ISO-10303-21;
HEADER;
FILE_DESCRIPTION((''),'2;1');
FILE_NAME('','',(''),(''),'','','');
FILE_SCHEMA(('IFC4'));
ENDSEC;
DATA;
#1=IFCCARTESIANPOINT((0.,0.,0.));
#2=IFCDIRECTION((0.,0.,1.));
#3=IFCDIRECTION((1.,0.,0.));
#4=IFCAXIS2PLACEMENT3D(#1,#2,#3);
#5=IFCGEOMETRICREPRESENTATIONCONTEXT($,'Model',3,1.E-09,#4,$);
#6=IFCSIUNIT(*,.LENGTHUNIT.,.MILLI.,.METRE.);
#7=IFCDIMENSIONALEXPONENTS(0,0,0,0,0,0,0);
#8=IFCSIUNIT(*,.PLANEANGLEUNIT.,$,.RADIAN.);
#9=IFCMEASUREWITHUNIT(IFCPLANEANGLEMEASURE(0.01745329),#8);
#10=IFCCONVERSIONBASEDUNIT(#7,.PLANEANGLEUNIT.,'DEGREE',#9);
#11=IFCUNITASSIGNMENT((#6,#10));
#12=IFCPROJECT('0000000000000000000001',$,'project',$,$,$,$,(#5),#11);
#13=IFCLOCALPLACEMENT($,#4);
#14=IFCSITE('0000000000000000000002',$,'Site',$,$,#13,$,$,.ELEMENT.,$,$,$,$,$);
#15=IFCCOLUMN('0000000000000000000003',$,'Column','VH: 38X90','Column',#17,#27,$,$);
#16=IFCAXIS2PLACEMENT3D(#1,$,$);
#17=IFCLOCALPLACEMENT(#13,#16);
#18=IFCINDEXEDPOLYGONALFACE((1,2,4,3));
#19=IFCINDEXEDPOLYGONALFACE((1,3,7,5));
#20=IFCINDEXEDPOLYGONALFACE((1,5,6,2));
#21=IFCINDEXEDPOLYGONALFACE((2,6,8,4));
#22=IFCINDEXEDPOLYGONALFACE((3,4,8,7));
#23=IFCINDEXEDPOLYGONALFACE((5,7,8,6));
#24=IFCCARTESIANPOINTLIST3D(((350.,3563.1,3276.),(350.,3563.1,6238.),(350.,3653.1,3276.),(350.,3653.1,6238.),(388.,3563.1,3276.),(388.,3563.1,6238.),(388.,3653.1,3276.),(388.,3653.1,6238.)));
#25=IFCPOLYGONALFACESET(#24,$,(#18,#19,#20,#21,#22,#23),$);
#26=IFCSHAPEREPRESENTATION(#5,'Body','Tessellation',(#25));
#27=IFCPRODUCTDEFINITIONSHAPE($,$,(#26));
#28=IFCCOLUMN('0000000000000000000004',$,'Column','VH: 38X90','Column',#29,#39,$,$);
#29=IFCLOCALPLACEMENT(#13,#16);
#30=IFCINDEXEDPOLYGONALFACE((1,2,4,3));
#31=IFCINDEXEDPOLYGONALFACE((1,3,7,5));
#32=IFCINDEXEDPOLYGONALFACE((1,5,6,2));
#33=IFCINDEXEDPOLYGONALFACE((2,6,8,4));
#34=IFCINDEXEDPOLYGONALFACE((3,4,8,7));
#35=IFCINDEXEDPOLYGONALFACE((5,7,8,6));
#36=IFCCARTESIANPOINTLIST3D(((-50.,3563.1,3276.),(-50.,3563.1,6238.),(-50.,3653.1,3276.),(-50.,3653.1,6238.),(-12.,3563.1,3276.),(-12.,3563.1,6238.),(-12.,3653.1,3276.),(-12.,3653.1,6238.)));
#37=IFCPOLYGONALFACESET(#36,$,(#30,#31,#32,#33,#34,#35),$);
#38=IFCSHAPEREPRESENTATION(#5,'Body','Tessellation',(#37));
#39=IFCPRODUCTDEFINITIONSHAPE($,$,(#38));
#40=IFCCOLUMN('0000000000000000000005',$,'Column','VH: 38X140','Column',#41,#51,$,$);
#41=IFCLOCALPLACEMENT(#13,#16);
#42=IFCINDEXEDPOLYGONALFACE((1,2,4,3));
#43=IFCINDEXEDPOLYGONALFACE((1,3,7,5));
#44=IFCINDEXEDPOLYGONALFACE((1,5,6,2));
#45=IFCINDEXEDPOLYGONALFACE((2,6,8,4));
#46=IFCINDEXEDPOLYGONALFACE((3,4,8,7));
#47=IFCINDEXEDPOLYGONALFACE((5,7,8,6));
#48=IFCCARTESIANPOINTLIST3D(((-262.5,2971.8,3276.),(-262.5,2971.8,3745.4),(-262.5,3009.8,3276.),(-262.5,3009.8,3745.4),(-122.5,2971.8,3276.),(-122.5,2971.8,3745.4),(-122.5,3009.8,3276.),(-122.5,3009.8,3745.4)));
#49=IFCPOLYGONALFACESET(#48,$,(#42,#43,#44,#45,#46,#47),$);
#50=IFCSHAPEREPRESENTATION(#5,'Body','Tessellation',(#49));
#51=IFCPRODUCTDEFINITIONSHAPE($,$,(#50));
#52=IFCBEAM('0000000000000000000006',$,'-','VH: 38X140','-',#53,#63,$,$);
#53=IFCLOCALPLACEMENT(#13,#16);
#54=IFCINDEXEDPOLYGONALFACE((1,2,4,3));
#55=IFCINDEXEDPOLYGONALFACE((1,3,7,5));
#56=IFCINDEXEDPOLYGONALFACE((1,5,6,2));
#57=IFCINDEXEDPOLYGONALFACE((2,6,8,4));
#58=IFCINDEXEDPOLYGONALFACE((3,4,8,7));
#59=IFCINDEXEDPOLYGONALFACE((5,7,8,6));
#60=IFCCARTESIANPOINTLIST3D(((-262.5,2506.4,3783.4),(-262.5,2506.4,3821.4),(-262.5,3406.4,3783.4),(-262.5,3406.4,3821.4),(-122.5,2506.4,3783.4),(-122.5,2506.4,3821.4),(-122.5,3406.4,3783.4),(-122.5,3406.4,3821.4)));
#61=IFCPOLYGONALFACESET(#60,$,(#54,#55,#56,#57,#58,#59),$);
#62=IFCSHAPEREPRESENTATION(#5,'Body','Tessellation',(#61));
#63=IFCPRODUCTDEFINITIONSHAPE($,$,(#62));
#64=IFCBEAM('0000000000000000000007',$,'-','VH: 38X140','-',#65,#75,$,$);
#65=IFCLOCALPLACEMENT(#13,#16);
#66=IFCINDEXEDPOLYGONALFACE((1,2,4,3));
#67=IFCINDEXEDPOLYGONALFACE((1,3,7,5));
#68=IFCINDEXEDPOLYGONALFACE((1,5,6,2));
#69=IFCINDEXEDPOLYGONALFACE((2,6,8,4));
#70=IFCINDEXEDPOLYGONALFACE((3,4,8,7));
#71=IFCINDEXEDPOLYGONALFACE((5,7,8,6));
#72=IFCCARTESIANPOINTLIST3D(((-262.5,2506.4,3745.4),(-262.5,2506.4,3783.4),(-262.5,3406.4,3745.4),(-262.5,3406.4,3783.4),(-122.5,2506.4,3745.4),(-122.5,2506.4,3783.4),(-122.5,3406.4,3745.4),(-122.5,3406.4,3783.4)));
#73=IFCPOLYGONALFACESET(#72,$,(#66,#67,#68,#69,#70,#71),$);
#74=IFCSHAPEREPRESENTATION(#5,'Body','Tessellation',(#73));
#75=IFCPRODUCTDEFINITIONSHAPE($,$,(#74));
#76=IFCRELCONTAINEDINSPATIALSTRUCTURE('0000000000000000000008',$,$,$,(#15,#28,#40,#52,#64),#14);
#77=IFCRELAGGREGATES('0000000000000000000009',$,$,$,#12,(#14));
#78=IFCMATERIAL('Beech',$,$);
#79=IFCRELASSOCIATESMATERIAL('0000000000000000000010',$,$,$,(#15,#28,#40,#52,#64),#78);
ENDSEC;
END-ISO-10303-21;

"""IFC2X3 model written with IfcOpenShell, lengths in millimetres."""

from ifc_helpers import new_model, entity, si_unit, converted_unit, frame, origin, origin_with_axes, origin_2d, place, context, project, spatial, rectangle, extrude, material, element, save


model = new_model("IFC2X3")

# Units and contexts
model_context = context("Model", 3, precision=1e-09, world=origin_with_axes())
ifc_project = project(units=[si_unit("LENGTHUNIT", "METRE", prefix="MILLI"), converted_unit("PLANEANGLEUNIT", "DEGREE", entity("IfcPlaneAngleMeasure", 0.01745329), si_unit("PLANEANGLEUNIT", "RADIAN"), dimensions=[0, 0, 0, 0, 0, 0, 0])], contexts=[model_context])

# Site
site_placement = place(None, origin_with_axes())
site = spatial("IfcSite", under=ifc_project, at=site_placement, Name="Site", CompositionType="ELEMENT")

# Columns
ifc_material = material(Name="Beech")
for number, where, z_axis, x_axis, name in (
    (1, (369.0, 3608.1, 3276.0), (0.0, 0.0, -1.0), (-1.0, 0.0, 0.0), "Column"),
    (2, (-31.0, 3608.1, 3276.0), (0.0, 0.0, -1.0), (-1.0, 0.0, 0.0), "Column"),
):
    element("IfcColumn", number, at=place(None, frame(where, z_axis=z_axis, x_axis=x_axis)), inside=site, material=ifc_material, Name=name, Description="VH: 38X90", ObjectType="Column", context=model_context, shape_type="SweptSolid", body=[
        extrude(rectangle(XDim=38.0, YDim=90.0, at=origin_2d()), origin(), (0.0, 0.0, -1.0), 2962.0),
    ])
column_1_placement = place(None, frame((-192.5, 2990.8, 3276.0), z_axis=(0.0, 0.0, -1.0), x_axis=(0.0, -1.0, 0.0)))
element("IfcColumn", 3, at=column_1_placement, inside=site, material=ifc_material, Name="Column", Description="VH: 38X140", ObjectType="Column", context=model_context, shape_type="SweptSolid", body=[
    extrude(rectangle(XDim=38.0, YDim=140.0, at=origin_2d()), origin(), (0.0, 0.0, -1.0), 469.4),
])

# Beams
for number, where, z_axis, x_axis, name in (
    (4, (-192.5, 3406.4, 3802.4), (0.0, 1.0, 0.0), (0.0, 0.0, -1.0), "-"),
    (5, (-192.5, 3406.4, 3764.4), (0.0, 1.0, 0.0), (0.0, 0.0, -1.0), "-"),
):
    element("IfcBeam", number, at=place(None, frame(where, z_axis=z_axis, x_axis=x_axis)), inside=site, material=ifc_material, Name=name, Description="VH: 38X140", ObjectType="-", context=model_context, shape_type="SweptSolid", body=[
        extrude(rectangle(XDim=38.0, YDim=140.0, at=origin_2d()), origin(), (0.0, 0.0, -1.0), 900.0),
    ])

save(model, "model.ifc")
